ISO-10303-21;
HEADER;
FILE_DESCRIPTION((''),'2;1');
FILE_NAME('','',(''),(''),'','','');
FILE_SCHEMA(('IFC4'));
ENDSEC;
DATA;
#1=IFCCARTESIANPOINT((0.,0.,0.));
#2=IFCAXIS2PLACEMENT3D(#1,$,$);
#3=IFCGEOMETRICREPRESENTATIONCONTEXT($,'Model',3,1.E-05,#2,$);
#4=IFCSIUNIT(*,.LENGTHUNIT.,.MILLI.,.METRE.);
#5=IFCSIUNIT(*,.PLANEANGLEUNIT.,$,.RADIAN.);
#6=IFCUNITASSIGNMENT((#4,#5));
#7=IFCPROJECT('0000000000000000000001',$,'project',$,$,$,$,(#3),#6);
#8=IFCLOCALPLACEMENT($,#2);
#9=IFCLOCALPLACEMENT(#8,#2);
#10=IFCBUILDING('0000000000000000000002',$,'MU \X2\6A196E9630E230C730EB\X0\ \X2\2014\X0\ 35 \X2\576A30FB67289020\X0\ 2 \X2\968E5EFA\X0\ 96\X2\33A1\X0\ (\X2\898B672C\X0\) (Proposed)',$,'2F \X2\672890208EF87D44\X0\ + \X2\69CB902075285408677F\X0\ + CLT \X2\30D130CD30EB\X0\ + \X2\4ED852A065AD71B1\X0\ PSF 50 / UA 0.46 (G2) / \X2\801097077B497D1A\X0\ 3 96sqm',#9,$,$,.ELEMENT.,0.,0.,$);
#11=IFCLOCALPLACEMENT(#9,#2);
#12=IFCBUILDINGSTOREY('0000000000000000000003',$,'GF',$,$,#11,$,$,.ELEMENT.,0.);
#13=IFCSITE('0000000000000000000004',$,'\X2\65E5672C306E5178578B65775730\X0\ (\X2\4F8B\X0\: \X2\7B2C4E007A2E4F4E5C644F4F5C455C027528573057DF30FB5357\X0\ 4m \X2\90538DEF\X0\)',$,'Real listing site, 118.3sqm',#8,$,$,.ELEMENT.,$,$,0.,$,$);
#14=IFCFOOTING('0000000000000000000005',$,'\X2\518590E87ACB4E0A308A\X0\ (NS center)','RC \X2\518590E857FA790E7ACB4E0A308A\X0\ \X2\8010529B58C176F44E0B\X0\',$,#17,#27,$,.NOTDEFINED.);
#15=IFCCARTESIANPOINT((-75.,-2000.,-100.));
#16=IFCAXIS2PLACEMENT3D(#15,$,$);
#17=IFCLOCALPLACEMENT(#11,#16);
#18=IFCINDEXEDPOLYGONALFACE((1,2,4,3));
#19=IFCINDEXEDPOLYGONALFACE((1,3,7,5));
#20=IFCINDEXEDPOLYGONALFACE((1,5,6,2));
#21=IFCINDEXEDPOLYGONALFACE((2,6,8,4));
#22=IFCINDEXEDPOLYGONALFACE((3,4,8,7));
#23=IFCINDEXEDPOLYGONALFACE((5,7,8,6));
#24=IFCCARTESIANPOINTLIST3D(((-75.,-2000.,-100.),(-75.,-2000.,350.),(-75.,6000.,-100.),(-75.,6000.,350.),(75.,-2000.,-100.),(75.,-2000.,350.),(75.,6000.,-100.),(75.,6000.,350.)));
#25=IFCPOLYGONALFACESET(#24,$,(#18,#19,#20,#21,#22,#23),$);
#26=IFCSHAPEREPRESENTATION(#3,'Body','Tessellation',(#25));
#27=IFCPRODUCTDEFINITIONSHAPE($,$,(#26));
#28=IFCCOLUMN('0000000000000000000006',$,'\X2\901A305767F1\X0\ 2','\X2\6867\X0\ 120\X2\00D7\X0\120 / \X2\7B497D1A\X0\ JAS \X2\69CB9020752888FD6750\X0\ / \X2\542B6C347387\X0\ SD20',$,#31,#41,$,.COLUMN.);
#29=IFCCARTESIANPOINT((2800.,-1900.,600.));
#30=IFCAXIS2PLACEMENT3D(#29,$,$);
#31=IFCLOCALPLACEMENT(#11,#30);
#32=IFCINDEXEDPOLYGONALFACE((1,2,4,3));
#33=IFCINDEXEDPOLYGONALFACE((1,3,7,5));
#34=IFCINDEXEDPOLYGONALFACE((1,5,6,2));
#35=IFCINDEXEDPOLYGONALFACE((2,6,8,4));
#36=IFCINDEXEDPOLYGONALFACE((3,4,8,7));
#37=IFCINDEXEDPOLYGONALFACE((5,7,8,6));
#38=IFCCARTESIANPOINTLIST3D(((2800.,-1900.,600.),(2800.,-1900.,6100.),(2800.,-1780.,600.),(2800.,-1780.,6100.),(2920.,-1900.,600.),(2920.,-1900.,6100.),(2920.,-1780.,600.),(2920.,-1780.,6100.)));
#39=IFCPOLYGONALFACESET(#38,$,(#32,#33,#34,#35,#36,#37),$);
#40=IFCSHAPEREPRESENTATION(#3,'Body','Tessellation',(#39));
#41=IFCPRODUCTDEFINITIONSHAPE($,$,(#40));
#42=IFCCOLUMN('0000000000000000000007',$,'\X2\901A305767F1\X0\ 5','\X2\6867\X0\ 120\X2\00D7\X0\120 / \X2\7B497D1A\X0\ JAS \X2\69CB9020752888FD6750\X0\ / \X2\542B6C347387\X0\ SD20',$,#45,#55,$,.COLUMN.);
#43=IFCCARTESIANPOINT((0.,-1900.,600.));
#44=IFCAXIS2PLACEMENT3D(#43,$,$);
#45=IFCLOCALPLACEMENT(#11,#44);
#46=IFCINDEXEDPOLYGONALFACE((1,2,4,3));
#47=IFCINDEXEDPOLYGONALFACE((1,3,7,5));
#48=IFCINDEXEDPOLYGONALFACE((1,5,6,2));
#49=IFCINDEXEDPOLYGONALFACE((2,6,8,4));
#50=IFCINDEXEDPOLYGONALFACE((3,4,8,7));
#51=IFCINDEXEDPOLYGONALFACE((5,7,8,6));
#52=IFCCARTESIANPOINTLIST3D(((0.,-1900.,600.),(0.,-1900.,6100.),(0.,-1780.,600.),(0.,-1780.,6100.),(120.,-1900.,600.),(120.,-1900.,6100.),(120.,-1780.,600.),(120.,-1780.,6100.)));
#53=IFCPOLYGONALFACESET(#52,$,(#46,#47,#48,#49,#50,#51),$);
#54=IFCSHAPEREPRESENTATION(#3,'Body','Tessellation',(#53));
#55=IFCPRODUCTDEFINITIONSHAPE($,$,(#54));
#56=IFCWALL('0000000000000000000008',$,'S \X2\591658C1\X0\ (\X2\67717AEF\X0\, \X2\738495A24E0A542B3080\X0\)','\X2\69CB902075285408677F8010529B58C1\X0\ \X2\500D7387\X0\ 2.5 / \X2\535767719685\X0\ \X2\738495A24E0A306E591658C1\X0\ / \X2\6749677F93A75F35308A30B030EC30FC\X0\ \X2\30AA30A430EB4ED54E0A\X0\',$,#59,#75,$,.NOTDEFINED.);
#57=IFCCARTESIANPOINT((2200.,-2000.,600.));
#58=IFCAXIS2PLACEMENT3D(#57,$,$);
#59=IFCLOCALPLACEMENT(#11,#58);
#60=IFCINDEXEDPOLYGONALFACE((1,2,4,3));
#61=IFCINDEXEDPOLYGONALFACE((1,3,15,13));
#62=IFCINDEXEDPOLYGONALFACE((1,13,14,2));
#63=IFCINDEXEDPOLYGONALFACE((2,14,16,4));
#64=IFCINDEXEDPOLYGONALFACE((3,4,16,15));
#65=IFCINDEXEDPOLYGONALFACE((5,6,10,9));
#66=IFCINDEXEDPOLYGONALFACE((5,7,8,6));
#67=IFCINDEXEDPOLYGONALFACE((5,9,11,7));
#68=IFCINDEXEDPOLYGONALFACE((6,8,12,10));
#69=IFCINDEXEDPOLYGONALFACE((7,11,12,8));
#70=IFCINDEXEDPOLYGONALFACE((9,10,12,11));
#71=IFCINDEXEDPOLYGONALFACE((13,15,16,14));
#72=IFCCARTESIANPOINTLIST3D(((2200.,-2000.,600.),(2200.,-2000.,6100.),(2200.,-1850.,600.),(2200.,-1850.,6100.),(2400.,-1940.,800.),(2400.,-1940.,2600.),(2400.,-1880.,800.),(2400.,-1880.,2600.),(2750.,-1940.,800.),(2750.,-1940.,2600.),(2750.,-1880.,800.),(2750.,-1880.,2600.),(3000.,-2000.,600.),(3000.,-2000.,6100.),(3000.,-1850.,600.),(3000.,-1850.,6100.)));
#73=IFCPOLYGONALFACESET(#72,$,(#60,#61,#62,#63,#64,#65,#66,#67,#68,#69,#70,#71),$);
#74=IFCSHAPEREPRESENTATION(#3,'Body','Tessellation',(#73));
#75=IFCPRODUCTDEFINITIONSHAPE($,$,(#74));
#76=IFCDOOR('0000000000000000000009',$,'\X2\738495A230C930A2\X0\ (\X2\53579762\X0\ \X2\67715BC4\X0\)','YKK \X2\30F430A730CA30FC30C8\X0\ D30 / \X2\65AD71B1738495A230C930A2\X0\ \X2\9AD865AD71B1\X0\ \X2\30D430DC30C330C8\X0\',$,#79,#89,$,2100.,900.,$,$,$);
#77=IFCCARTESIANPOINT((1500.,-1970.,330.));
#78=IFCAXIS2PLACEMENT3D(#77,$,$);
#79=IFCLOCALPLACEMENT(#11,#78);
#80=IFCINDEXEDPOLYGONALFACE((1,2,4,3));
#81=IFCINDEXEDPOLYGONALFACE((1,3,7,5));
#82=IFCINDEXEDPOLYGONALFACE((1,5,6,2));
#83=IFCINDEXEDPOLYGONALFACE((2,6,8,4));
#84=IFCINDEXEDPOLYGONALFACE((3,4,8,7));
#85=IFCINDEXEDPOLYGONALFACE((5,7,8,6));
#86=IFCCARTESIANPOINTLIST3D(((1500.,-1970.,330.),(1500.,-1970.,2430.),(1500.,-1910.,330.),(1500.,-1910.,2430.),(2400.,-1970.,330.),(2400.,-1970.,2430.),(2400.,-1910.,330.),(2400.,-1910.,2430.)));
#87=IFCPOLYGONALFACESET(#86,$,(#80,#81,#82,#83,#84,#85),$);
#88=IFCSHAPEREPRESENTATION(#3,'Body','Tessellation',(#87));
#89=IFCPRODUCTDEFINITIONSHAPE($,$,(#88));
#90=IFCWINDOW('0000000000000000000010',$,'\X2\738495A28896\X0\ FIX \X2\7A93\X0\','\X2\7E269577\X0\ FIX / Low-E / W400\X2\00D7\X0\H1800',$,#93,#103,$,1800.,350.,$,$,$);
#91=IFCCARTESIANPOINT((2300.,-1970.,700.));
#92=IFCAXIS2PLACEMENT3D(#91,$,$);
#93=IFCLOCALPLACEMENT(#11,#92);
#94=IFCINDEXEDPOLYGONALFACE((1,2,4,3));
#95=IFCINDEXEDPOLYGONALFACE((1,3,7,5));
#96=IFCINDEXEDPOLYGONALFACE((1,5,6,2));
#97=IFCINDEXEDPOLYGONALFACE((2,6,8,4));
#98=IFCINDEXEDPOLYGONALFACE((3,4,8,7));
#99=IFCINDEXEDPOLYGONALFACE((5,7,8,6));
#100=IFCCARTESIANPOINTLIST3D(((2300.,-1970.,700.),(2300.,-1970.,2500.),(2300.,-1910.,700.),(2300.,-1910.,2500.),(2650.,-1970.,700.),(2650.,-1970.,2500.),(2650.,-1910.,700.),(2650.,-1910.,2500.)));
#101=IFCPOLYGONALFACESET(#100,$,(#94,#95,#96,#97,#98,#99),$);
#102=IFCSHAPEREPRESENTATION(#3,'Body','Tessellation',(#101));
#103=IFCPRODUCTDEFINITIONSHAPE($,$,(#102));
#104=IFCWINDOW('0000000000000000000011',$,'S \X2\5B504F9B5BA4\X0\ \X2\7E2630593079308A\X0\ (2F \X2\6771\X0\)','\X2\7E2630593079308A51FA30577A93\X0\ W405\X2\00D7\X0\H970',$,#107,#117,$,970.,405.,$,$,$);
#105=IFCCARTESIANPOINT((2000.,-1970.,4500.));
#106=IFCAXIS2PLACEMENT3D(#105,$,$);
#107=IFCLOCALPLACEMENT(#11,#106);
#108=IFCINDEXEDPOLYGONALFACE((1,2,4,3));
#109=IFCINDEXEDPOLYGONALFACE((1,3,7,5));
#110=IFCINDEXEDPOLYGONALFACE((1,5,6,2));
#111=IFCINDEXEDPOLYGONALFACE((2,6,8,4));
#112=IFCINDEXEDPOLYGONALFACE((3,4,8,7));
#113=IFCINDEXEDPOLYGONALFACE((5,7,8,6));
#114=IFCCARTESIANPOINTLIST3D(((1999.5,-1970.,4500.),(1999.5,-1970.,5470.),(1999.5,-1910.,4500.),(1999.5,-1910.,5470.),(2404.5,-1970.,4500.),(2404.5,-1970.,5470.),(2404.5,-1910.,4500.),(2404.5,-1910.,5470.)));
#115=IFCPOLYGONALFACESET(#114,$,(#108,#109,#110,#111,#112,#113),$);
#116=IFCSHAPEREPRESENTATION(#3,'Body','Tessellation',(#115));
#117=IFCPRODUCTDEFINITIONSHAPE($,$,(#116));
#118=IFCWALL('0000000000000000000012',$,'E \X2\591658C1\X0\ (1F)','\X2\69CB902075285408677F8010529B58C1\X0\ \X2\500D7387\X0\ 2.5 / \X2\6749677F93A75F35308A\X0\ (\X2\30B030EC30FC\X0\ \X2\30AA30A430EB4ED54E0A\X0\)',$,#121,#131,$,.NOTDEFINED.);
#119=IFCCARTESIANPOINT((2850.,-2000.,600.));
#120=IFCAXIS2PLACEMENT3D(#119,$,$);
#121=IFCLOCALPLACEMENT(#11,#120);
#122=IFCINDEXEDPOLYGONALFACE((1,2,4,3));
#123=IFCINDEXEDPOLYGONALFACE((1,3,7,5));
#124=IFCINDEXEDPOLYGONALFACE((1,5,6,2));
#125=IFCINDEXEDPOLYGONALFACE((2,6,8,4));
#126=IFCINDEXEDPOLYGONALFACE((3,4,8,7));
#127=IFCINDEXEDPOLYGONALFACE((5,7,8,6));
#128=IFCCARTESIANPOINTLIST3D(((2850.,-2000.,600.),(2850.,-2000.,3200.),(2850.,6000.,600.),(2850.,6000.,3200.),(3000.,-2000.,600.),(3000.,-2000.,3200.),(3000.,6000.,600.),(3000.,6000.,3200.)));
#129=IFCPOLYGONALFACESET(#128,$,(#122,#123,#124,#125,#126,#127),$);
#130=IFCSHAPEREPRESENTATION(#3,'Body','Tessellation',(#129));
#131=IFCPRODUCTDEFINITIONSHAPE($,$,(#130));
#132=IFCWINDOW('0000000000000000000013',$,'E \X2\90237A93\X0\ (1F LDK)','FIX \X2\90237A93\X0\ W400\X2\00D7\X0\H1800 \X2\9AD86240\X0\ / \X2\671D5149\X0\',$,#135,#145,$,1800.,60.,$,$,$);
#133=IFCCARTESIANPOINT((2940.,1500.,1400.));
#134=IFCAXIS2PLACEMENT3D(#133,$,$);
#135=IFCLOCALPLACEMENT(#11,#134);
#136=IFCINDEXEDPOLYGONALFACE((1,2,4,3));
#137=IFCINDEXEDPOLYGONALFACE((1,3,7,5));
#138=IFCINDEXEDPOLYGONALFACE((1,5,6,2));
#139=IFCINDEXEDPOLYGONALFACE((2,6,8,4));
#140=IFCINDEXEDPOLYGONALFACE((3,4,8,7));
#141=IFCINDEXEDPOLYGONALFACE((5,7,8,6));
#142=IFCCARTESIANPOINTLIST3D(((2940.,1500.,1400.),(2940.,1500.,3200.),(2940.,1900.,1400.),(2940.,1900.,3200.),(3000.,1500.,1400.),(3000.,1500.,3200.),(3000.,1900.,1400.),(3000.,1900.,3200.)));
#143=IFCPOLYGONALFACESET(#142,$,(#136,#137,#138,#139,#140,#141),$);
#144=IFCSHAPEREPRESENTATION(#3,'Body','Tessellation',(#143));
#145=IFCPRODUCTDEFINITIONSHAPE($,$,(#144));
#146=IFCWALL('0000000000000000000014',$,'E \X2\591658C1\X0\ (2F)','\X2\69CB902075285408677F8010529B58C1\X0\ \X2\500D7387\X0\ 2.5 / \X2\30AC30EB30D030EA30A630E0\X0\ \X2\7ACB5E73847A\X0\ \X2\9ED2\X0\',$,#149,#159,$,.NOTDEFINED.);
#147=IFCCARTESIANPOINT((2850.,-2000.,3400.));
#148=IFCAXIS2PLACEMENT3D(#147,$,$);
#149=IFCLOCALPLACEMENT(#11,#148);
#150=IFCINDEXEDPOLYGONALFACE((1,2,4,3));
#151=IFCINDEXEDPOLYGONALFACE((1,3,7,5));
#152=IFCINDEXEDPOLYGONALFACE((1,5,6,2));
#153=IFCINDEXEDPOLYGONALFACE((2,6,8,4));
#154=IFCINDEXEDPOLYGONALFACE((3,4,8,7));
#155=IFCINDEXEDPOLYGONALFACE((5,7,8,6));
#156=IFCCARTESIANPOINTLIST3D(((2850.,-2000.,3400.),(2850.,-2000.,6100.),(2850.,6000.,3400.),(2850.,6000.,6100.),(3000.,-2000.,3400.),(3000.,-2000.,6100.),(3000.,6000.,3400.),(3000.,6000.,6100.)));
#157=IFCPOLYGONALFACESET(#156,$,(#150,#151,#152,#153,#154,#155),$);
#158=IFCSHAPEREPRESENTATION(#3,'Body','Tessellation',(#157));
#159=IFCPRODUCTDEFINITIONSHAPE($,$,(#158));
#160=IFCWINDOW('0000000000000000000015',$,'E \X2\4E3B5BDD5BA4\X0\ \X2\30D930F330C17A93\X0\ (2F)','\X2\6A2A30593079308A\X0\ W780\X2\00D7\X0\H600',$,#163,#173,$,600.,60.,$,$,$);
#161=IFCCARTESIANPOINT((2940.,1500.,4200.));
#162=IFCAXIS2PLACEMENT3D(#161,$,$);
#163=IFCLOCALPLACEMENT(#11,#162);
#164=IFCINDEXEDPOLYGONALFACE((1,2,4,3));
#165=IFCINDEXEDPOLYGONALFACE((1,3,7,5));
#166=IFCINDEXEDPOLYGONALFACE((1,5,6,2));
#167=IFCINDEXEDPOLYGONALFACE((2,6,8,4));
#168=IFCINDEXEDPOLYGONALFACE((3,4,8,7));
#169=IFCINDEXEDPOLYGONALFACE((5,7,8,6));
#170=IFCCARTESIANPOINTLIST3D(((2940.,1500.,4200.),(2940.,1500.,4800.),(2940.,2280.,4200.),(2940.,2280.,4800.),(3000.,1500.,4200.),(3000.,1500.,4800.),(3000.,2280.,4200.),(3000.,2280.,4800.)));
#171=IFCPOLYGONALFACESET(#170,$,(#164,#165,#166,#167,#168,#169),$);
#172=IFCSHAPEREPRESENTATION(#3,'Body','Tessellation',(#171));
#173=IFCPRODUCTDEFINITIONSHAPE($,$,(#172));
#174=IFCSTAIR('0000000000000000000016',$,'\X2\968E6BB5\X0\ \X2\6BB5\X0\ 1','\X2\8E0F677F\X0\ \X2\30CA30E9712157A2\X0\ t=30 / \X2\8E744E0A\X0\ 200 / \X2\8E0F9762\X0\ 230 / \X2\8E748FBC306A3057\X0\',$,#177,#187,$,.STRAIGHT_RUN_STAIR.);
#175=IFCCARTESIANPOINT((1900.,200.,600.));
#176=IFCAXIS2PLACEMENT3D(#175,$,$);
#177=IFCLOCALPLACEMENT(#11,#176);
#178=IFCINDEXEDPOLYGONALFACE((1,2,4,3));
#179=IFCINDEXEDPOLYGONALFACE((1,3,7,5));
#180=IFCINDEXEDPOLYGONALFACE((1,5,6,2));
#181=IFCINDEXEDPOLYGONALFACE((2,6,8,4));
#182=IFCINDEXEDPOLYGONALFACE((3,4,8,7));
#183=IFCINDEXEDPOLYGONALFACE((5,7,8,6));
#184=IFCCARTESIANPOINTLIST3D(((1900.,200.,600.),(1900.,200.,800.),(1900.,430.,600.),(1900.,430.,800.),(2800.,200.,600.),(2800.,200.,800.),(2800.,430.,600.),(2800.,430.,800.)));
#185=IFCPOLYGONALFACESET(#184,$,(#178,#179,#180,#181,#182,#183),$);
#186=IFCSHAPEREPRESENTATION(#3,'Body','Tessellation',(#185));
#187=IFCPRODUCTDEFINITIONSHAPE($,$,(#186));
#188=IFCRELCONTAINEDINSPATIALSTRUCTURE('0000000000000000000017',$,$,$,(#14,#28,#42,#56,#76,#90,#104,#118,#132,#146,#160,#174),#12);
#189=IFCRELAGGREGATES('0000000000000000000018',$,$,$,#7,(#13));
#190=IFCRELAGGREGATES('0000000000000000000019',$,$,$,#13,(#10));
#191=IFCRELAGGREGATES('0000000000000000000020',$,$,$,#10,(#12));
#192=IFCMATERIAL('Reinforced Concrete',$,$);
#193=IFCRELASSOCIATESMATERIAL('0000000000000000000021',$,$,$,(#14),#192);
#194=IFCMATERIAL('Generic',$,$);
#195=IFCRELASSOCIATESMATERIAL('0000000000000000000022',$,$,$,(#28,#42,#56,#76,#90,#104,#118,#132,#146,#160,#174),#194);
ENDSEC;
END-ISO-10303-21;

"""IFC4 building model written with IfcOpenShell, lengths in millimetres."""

from ifc_helpers import new_model, si_unit, frame, frame_2d, origin, place, context, project, spatial, rectangle, extrude, material, element, fill, save


model = new_model("IFC4")

# Units and contexts
model_context = context("Model", 3, precision=1e-05, world=origin())
ifc_project = project(units=[si_unit("LENGTHUNIT", "METRE", prefix="MILLI"), si_unit("PLANEANGLEUNIT", "RADIAN")], contexts=[model_context])

# Site, building, storey
site_placement = place(None, origin())
site = spatial("IfcSite", under=ifc_project, at=site_placement, Name="日本の典型敷地 (例: 第一種低層住居専用地域・南 4m 道路)", ObjectType="Real listing site, 118.3sqm", CompositionType="ELEMENT", RefElevation=0.0)
building_placement = place(site_placement, origin())
building = spatial("IfcBuilding", under=site, at=building_placement, Name="MU 標準モデル — 35 坪・木造 2 階建 96㎡ (見本) (Proposed)", ObjectType="2F 木造軸組 + 構造用合板 + CLT パネル + 付加断熱 PSF 50 / UA 0.46 (G2) / 耐震等級 3 96sqm", CompositionType="ELEMENT", ElevationOfRefHeight=0.0, ElevationOfTerrain=0.0)
storey_placement = place(building_placement, origin())
storey = spatial("IfcBuildingStorey", under=building, at=storey_placement, Name="GF", CompositionType="ELEMENT", Elevation=0.0)

# Footing
ifc_material_1 = material(Name="Reinforced Concrete")
footing_placement = place(storey_placement, frame((-75.0, -2000.0, -100.0)))
element("IfcFooting", 1, at=footing_placement, inside=storey, material=ifc_material_1, Name="内部立上り (NS center)", Description="RC 内部基礎立上り 耐力壁直下", PredefinedType="NOTDEFINED", context=model_context, shape_type="SweptSolid", body=[
    extrude(rectangle(XDim=150.0, YDim=8000.0, at=frame_2d((75.0, 4000.0))), frame((-75.0, -2000.0, -100.0)), (0.0, 0.0, 1.0), 450.0),
])

# Columns
ifc_material_2 = material(Name="Generic")
column_1_placement = place(storey_placement, frame((2800.0, -1900.0, 600.0)))
element("IfcColumn", 2, at=column_1_placement, inside=storey, material=ifc_material_2, Name="通し柱 2", Description="桧 120×120 / 等級 JAS 構造用製材 / 含水率 SD20", PredefinedType="COLUMN", context=model_context, shape_type="SweptSolid", body=[
    extrude(rectangle(XDim=120.0, YDim=120.0, at=frame_2d((60.0, 60.0))), frame((2800.0, -1900.0, 600.0)), (0.0, 0.0, 1.0), 5500.0),
])
column_2_placement = place(storey_placement, frame((0.0, -1900.0, 600.0)))
element("IfcColumn", 3, at=column_2_placement, inside=storey, material=ifc_material_2, Name="通し柱 5", Description="桧 120×120 / 等級 JAS 構造用製材 / 含水率 SD20", PredefinedType="COLUMN", context=model_context, shape_type="SweptSolid", body=[
    extrude(rectangle(XDim=120.0, YDim=120.0, at=frame_2d((60.0, 60.0))), frame((0.0, -1900.0, 600.0)), (0.0, 0.0, 1.0), 5500.0),
])

# Wall, openings, door, windows
wall_1_placement = place(storey_placement, frame((2200.0, -2000.0, 600.0)))
wall_1 = element("IfcWall", 4, at=wall_1_placement, inside=storey, material=ifc_material_2, Name="S 外壁 (東端, 玄関上含む)", Description="構造用合板耐力壁 倍率 2.5 / 南東隅 玄関上の外壁 / 杉板鎧張りグレー オイル仕上", PredefinedType="NOTDEFINED", context=model_context, shape_type="SweptSolid", body=[
    extrude(rectangle(XDim=800.0, YDim=150.0, at=frame_2d((400.0, 75.0))), frame((2200.0, -2000.0, 600.0)), (0.0, 0.0, 1.0), 5500.0),
])
opening_1_placement = place(storey_placement, frame((1500.0, -1970.0, 330.0)))
opening_1 = element("IfcOpeningElement", 5, at=opening_1_placement, cuts=wall_1, PredefinedType="NOTDEFINED", context=model_context, shape_type="SweptSolid", body=[
    extrude(rectangle(XDim=900.0, YDim=60.0, at=frame_2d((450.0, 30.0))), frame((1500.0, -1970.0, 330.0)), (0.0, 0.0, 1.0), 2100.0),
])
opening_2_placement = place(storey_placement, frame((2300.0, -1970.0, 700.0)))
opening_2 = element("IfcOpeningElement", 6, at=opening_2_placement, cuts=wall_1, PredefinedType="NOTDEFINED", context=model_context, shape_type="SweptSolid", body=[
    extrude(rectangle(XDim=350.0, YDim=60.0, at=frame_2d((175.0, 30.0))), frame((2300.0, -1970.0, 700.0)), (0.0, 0.0, 1.0), 1800.0),
])
opening_3_placement = place(storey_placement, frame((2000.0, -1970.0, 4500.0)))
opening_3 = element("IfcOpeningElement", 7, at=opening_3_placement, cuts=wall_1, PredefinedType="NOTDEFINED", context=model_context, shape_type="SweptSolid", body=[
    extrude(rectangle(XDim=405.0, YDim=60.0, at=frame_2d((202.0, 30.0))), frame((2000.0, -1970.0, 4500.0)), (0.0, 0.0, 1.0), 970.0),
])
door_placement = place(storey_placement, frame((1500.0, -1970.0, 330.0)))
door = element("IfcDoor", 8, at=door_placement, inside=storey, material=ifc_material_2, Name="玄関ドア (南面 東寄)", Description="YKK ヴェナート D30 / 断熱玄関ドア 高断熱 ピボット", OverallHeight=2100.0, OverallWidth=900.0, context=model_context, shape_type="SweptSolid", body=[
    extrude(rectangle(XDim=900.0, YDim=60.0, at=frame_2d((450.0, 30.0))), frame((1500.0, -1970.0, 330.0)), (0.0, 0.0, 1.0), 2100.0),
])
fill(opening_1, door)
window_1_placement = place(storey_placement, frame((2300.0, -1970.0, 700.0)))
window_1 = element("IfcWindow", 9, at=window_1_placement, inside=storey, material=ifc_material_2, Name="玄関袖 FIX 窓", Description="縦長 FIX / Low-E / W400×H1800", OverallHeight=1800.0, OverallWidth=350.0, context=model_context, shape_type="SweptSolid", body=[
    extrude(rectangle(XDim=350.0, YDim=60.0, at=frame_2d((175.0, 30.0))), frame((2300.0, -1970.0, 700.0)), (0.0, 0.0, 1.0), 1800.0),
])
fill(opening_2, window_1)
window_2_placement = place(storey_placement, frame((2000.0, -1970.0, 4500.0)))
window_2 = element("IfcWindow", 10, at=window_2_placement, inside=storey, material=ifc_material_2, Name="S 子供室 縦すべり (2F 東)", Description="縦すべり出し窓 W405×H970", OverallHeight=970.0, OverallWidth=405.0, context=model_context, shape_type="SweptSolid", body=[
    extrude(rectangle(XDim=405.0, YDim=60.0, at=frame_2d((202.0, 30.0))), frame((2000.0, -1970.0, 4500.0)), (0.0, 0.0, 1.0), 970.0),
])
fill(opening_3, window_2)

# Walls, openings, windows
wall_2_placement = place(storey_placement, frame((2850.0, -2000.0, 600.0)))
wall_2 = element("IfcWall", 11, at=wall_2_placement, inside=storey, material=ifc_material_2, Name="E 外壁 (1F)", Description="構造用合板耐力壁 倍率 2.5 / 杉板鎧張り (グレー オイル仕上)", PredefinedType="NOTDEFINED", context=model_context, shape_type="SweptSolid", body=[
    extrude(rectangle(XDim=150.0, YDim=8000.0, at=frame_2d((75.0, 4000.0))), frame((2850.0, -2000.0, 600.0)), (0.0, 0.0, 1.0), 2600.0),
])
opening_4_placement = place(storey_placement, frame((2940.0, 1500.0, 1400.0)))
opening_4 = element("IfcOpeningElement", 12, at=opening_4_placement, cuts=wall_2, PredefinedType="NOTDEFINED", context=model_context, shape_type="SweptSolid", body=[
    extrude(rectangle(XDim=60.0, YDim=400.0, at=frame_2d((30.0, 200.0))), frame((2940.0, 1500.0, 1400.0)), (0.0, 0.0, 1.0), 1800.0),
])
window_3_placement = place(storey_placement, frame((2940.0, 1500.0, 1400.0)))
window_3 = element("IfcWindow", 13, at=window_3_placement, inside=storey, material=ifc_material_2, Name="E 連窓 (1F LDK)", Description="FIX 連窓 W400×H1800 高所 / 朝光", OverallHeight=1800.0, OverallWidth=60.0, context=model_context, shape_type="SweptSolid", body=[
    extrude(rectangle(XDim=60.0, YDim=400.0, at=frame_2d((30.0, 200.0))), frame((2940.0, 1500.0, 1400.0)), (0.0, 0.0, 1.0), 1800.0),
])
fill(opening_4, window_3)
wall_3_placement = place(storey_placement, frame((2850.0, -2000.0, 3400.0)))
wall_3 = element("IfcWall", 14, at=wall_3_placement, inside=storey, material=ifc_material_2, Name="E 外壁 (2F)", Description="構造用合板耐力壁 倍率 2.5 / ガルバリウム 立平葺 黒", PredefinedType="NOTDEFINED", context=model_context, shape_type="SweptSolid", body=[
    extrude(rectangle(XDim=150.0, YDim=8000.0, at=frame_2d((75.0, 4000.0))), frame((2850.0, -2000.0, 3400.0)), (0.0, 0.0, 1.0), 2700.0),
])
opening_5_placement = place(storey_placement, frame((2940.0, 1500.0, 4200.0)))
opening_5 = element("IfcOpeningElement", 15, at=opening_5_placement, cuts=wall_3, PredefinedType="NOTDEFINED", context=model_context, shape_type="SweptSolid", body=[
    extrude(rectangle(XDim=60.0, YDim=780.0, at=frame_2d((30.0, 390.0))), frame((2940.0, 1500.0, 4200.0)), (0.0, 0.0, 1.0), 600.0),
])
window_4_placement = place(storey_placement, frame((2940.0, 1500.0, 4200.0)))
window_4 = element("IfcWindow", 16, at=window_4_placement, inside=storey, material=ifc_material_2, Name="E 主寝室 ベンチ窓 (2F)", Description="横すべり W780×H600", OverallHeight=600.0, OverallWidth=60.0, context=model_context, shape_type="SweptSolid", body=[
    extrude(rectangle(XDim=60.0, YDim=780.0, at=frame_2d((30.0, 390.0))), frame((2940.0, 1500.0, 4200.0)), (0.0, 0.0, 1.0), 600.0),
])
fill(opening_5, window_4)

# Stair
stair_placement = place(storey_placement, frame((1900.0, 200.0, 600.0)))
element("IfcStair", 17, at=stair_placement, inside=storey, material=ifc_material_2, Name="階段 段 1", Description="踏板 ナラ無垢 t=30 / 蹴上 200 / 踏面 230 / 蹴込なし", PredefinedType="STRAIGHT_RUN_STAIR", context=model_context, shape_type="SweptSolid", body=[
    extrude(rectangle(XDim=900.0, YDim=230.0, at=frame_2d((450.0, 115.0))), frame((1900.0, 200.0, 600.0)), (0.0, 0.0, 1.0), 200.0),
])

save(model, "model.ifc")
